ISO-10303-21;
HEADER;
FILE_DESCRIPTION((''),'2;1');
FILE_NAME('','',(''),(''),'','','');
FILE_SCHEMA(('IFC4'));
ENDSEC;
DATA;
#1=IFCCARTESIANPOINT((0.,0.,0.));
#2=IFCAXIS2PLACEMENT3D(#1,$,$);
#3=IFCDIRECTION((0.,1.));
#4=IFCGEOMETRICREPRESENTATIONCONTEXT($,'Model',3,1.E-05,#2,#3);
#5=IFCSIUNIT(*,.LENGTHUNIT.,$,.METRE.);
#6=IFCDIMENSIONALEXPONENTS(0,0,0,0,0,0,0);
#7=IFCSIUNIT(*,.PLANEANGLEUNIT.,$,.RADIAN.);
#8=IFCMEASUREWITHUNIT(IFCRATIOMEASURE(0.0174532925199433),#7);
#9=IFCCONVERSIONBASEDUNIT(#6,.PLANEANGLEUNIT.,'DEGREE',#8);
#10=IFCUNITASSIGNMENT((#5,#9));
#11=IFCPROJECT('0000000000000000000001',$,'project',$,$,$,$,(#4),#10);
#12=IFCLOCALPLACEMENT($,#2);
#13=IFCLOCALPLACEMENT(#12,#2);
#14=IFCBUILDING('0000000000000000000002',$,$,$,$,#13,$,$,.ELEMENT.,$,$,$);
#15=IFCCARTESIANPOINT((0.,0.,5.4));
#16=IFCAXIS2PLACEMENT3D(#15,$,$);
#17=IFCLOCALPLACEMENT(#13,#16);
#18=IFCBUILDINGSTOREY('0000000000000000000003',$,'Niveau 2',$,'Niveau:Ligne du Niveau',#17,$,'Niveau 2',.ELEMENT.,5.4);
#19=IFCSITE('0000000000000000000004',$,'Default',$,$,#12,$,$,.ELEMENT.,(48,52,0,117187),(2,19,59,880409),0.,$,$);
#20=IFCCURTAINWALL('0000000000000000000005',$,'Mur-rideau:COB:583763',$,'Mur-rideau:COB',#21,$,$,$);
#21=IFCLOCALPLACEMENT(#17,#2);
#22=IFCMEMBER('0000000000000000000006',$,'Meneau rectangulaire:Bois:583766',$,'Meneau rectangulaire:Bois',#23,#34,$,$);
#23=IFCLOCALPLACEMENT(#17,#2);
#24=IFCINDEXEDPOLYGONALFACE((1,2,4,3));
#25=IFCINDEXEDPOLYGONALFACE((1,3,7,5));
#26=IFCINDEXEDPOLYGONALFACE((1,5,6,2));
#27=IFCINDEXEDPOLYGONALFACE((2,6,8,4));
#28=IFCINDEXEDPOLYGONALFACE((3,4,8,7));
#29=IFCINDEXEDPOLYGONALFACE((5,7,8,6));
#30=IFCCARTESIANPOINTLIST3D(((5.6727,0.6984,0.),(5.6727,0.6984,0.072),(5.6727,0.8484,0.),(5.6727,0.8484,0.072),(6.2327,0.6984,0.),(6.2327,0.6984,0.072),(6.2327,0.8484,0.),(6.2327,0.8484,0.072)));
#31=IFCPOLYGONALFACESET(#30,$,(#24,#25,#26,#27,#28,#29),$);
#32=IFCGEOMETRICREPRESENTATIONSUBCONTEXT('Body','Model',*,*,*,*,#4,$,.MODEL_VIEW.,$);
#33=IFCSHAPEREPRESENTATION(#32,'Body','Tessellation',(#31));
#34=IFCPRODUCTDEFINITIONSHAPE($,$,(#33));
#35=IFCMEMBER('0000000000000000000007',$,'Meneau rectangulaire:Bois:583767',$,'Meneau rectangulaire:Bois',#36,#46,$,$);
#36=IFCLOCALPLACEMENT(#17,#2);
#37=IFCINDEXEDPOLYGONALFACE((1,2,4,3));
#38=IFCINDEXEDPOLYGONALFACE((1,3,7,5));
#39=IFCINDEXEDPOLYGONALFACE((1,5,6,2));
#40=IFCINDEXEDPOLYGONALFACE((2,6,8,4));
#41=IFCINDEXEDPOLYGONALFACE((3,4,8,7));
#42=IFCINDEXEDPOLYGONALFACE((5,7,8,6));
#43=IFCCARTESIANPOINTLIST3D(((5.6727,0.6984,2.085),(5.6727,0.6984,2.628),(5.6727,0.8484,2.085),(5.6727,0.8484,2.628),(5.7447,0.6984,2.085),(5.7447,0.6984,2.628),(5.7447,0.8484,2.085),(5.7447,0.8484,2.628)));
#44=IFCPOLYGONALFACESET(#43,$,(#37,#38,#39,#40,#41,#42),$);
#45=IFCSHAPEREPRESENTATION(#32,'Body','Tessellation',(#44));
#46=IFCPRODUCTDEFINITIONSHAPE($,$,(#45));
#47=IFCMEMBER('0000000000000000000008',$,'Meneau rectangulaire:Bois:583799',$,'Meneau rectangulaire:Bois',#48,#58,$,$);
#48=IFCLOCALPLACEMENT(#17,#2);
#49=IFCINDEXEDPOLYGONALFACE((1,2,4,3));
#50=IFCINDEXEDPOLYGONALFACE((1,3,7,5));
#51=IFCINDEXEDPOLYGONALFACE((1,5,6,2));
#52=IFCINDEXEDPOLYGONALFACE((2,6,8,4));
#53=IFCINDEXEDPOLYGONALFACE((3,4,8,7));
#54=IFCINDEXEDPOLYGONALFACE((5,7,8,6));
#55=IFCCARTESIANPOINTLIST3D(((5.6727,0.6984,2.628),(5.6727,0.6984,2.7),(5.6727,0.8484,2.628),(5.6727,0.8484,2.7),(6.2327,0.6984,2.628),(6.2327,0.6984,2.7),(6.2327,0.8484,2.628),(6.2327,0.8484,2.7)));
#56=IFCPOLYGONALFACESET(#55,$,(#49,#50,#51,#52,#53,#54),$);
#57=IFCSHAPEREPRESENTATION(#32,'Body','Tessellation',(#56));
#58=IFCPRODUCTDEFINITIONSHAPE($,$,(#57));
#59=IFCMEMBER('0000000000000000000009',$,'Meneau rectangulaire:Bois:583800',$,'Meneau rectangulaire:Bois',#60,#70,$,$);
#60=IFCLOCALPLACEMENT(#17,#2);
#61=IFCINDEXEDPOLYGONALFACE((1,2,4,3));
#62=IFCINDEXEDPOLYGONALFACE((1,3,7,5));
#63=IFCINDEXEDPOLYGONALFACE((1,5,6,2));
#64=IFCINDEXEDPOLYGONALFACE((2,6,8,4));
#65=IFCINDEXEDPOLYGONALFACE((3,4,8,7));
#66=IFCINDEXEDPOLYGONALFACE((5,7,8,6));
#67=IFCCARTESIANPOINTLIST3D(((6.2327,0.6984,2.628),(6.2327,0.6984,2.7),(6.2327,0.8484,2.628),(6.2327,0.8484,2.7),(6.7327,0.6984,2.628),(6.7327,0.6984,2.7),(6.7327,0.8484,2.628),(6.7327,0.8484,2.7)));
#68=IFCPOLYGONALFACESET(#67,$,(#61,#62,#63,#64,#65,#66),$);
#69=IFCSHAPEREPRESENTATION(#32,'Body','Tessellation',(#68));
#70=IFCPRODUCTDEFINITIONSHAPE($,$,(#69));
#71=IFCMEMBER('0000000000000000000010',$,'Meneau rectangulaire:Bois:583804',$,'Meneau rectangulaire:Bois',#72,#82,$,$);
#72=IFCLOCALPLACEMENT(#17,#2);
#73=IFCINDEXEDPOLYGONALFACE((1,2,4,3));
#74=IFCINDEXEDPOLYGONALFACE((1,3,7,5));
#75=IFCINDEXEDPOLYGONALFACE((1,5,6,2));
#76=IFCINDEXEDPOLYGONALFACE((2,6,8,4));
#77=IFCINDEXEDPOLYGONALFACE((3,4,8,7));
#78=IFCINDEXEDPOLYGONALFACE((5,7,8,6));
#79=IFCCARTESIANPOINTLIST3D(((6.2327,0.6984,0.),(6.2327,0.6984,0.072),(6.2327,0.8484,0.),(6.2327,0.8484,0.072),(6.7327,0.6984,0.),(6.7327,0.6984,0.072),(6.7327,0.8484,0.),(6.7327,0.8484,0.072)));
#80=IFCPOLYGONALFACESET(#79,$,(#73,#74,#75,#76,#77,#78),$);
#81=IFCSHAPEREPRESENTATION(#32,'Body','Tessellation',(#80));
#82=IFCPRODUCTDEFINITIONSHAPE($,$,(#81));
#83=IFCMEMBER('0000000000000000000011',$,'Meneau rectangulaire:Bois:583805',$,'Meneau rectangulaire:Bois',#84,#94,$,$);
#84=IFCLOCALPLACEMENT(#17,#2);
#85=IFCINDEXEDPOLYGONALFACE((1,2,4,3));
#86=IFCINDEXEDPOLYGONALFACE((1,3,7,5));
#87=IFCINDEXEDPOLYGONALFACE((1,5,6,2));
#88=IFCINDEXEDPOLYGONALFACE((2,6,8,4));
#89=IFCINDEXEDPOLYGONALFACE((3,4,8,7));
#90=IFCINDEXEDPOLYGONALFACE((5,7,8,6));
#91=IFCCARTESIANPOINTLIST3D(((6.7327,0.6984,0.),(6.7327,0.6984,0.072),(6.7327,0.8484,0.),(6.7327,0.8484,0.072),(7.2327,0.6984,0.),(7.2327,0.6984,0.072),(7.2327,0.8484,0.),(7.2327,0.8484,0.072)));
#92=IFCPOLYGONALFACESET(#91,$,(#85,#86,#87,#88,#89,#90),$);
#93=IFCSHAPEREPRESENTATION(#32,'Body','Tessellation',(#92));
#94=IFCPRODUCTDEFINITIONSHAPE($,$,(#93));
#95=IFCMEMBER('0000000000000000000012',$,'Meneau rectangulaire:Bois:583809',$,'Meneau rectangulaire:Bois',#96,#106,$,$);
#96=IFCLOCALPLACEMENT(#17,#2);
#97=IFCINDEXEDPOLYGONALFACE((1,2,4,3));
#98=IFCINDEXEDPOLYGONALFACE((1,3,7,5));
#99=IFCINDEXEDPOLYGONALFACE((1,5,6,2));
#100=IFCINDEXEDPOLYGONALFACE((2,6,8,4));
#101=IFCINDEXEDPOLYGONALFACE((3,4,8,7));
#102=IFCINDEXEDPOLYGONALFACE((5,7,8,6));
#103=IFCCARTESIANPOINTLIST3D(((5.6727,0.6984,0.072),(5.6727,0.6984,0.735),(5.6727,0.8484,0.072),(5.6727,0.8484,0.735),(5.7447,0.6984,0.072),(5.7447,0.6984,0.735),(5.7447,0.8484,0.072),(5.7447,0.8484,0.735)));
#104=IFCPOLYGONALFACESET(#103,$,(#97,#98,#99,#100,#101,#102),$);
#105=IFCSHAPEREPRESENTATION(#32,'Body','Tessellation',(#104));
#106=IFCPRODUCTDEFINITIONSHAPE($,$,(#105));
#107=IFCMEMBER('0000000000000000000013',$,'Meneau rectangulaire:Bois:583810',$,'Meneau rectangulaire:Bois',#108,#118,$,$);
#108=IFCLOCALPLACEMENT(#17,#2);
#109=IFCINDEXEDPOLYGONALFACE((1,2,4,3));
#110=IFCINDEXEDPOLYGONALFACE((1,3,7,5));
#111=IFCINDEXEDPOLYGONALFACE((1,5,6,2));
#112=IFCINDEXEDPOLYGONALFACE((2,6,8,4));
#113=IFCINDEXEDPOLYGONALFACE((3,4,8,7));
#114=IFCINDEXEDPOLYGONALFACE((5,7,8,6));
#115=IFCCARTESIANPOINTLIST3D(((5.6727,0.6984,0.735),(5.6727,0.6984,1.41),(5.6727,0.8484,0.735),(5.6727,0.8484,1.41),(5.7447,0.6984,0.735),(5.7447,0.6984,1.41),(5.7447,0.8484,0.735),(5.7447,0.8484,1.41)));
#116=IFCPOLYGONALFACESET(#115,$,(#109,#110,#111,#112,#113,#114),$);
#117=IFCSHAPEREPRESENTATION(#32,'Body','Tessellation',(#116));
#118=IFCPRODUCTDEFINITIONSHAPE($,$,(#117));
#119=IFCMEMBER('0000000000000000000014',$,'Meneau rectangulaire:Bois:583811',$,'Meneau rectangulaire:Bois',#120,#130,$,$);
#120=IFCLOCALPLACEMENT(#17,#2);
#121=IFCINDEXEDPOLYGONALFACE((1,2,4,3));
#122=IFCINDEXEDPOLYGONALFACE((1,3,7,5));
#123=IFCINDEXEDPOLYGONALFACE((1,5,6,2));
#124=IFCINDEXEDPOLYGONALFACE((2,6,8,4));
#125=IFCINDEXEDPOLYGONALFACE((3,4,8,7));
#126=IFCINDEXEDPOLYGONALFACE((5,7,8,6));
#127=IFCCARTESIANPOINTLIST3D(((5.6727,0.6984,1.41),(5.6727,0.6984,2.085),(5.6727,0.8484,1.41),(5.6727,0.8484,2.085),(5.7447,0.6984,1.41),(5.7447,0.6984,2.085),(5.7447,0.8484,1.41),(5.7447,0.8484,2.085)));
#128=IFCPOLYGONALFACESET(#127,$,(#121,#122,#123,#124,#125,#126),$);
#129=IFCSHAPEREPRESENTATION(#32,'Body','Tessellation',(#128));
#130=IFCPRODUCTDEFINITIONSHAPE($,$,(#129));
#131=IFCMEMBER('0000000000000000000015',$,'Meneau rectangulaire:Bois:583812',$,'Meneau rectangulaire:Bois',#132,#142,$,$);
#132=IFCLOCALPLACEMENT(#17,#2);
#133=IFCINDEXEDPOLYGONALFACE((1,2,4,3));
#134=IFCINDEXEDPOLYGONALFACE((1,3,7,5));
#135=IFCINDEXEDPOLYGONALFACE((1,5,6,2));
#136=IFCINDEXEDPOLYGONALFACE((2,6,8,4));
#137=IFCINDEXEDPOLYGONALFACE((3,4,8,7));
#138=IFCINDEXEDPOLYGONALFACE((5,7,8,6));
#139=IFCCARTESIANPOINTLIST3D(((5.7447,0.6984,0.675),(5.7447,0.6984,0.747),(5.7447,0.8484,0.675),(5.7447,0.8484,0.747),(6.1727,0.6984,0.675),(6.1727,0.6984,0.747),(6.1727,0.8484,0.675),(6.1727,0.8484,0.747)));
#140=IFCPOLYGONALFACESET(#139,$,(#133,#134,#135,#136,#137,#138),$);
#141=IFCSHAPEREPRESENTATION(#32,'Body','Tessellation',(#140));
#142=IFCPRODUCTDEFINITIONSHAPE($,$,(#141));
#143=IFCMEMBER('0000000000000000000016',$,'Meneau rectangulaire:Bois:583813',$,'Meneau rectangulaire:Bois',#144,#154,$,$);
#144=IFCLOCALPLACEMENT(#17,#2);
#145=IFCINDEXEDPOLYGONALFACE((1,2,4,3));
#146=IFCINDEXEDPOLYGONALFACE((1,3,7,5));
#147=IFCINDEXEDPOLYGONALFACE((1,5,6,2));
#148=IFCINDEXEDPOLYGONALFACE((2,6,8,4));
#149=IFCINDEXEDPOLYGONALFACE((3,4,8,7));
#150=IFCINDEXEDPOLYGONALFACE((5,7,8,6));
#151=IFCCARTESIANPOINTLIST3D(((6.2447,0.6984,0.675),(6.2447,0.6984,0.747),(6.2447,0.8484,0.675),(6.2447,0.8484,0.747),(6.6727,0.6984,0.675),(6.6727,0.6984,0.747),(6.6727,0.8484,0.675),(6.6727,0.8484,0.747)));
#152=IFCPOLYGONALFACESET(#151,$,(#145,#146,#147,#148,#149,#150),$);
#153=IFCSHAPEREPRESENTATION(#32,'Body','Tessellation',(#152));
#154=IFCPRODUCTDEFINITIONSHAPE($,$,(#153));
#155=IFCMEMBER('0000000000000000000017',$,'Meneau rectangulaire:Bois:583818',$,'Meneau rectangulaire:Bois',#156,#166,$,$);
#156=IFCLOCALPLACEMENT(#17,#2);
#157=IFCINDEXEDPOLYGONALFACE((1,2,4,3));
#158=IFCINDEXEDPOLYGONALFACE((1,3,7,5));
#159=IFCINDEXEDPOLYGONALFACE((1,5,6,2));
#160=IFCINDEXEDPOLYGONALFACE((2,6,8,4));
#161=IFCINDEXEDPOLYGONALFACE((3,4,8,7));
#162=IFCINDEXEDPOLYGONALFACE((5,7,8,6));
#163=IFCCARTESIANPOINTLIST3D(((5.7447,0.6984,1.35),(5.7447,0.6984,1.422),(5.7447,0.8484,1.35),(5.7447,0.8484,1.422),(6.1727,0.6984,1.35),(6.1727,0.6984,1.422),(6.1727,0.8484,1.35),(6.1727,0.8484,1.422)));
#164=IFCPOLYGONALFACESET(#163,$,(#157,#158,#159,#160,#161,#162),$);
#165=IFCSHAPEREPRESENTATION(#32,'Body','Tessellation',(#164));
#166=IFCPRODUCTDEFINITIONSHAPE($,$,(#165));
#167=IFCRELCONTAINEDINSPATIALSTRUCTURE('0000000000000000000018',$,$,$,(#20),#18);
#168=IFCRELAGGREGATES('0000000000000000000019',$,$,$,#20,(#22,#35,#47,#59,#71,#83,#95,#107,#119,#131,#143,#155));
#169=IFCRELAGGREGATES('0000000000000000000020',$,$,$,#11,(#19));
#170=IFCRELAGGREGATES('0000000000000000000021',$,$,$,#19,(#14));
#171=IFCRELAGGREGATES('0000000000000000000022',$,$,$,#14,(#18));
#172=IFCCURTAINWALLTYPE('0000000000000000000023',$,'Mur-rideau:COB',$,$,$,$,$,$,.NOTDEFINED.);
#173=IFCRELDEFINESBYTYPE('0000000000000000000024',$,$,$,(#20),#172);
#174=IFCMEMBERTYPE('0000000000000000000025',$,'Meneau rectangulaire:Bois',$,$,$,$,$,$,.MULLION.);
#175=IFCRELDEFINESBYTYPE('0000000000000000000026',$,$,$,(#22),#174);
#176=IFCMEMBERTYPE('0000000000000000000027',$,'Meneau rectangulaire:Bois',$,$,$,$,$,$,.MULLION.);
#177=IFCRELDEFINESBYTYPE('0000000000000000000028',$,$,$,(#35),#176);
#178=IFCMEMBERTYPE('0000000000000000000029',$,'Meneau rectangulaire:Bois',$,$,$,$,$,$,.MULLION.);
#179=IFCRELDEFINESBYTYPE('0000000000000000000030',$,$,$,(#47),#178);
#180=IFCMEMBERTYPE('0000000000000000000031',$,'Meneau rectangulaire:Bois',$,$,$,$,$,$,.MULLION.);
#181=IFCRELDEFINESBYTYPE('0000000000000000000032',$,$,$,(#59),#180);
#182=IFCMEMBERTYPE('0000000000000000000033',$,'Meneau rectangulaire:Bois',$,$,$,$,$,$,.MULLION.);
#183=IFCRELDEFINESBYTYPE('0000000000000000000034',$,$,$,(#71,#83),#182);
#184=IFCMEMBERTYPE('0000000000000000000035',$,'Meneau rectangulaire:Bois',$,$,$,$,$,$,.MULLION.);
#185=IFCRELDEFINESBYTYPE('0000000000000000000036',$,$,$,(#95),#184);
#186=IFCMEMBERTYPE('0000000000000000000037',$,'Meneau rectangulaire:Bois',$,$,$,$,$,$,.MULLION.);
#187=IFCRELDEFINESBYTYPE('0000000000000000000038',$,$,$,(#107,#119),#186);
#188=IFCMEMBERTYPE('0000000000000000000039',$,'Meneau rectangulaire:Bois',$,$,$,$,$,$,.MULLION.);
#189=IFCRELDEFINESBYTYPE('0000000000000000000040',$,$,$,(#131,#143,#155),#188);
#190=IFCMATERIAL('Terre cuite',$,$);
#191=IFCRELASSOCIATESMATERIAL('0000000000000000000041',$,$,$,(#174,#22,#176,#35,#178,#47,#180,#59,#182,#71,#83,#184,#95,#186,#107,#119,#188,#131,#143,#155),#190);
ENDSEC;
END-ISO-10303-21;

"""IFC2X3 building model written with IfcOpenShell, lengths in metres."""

from ifc_helpers import new_model, entity, si_unit, converted_unit, direction, frame, origin, origin_2d_with_axis, place, context, subcontext, project, spatial, rectangle, extrude, source, transform, mapped, material, type_object, type_shapes, element, aggregate, save


model = new_model("IFC2X3")

# Units and contexts
model_context = context("Model", 3, precision=1e-05, world=origin(), true_north=direction((0.0, 1.0)))
body_context = subcontext(model_context, "Body", "Model", "MODEL_VIEW")
ifc_project = project(units=[si_unit("LENGTHUNIT", "METRE"), converted_unit("PLANEANGLEUNIT", "DEGREE", entity("IfcRatioMeasure", 0.0174532925199433), si_unit("PLANEANGLEUNIT", "RADIAN"), dimensions=[0, 0, 0, 0, 0, 0, 0])], contexts=[model_context])

# Site, building, storey
site_placement = place(None, origin())
site = spatial("IfcSite", under=ifc_project, at=site_placement, Name="Default", CompositionType="ELEMENT", RefLatitude=(48, 52, 0, 117187), RefLongitude=(2, 19, 59, 880409), RefElevation=0.0)
building_placement = place(site_placement, origin())
building = spatial("IfcBuilding", under=site, at=building_placement, CompositionType="ELEMENT")
storey_placement = place(building_placement, frame((0.0, 0.0, 5.4)))
storey = spatial("IfcBuildingStorey", under=building, at=storey_placement, Name="Niveau 2", ObjectType="Niveau:Ligne du Niveau", LongName="Niveau 2", CompositionType="ELEMENT", Elevation=5.4)

# Curtain wall, members
curtain_wall_type_1 = type_object("IfcCurtainWallType", Name="Mur-rideau:COB", PredefinedType="NOTDEFINED")
curtain_wall_1_placement = place(storey_placement, frame((0.0, 0.0, -5.4)))
curtain_wall_1 = element("IfcCurtainWall", 1, at=curtain_wall_1_placement, inside=storey, type_object=curtain_wall_type_1, Name="Mur-rideau:COB:583763", ObjectType="Mur-rideau:COB")
ifc_material_1 = material(Name="Terre cuite")
member_type_1 = type_object("IfcMemberType", Name="Meneau rectangulaire:Bois", PredefinedType="MULLION", material=ifc_material_1)
shared_shape_1 = source(origin(), body_context, "Body", "SweptSolid", [
    extrude(rectangle(XDim=0.15, YDim=0.072, at=origin_2d_with_axis()), frame((-0.036, 0.0, -0.56), z_axis=(0.0, 0.0, 1.0), x_axis=(0.0, -1.0, 0.0)), (0.0, 0.0, 1.0), 0.56),
])
type_shapes(member_type_1, [shared_shape_1])
member_1_placement = place(storey_placement, frame((5.6727, 0.7734, 0.0), z_axis=(-1.0, 0.0, 0.0), x_axis=(0.0, 0.0, -1.0)))
member_1 = element("IfcMember", 2, at=member_1_placement, type_object=member_type_1, material=ifc_material_1, Name="Meneau rectangulaire:Bois:583766", ObjectType="Meneau rectangulaire:Bois", context=body_context, shape_type="MappedRepresentation", body=[
    mapped(shared_shape_1, transform((0.0, 0.0, 0.0), scale=1.0)),
])
member_type_2 = type_object("IfcMemberType", Name="Meneau rectangulaire:Bois", PredefinedType="MULLION", material=ifc_material_1)
shared_shape_2 = source(origin(), body_context, "Body", "SweptSolid", [
    extrude(rectangle(XDim=0.15, YDim=0.072, at=origin_2d_with_axis()), frame((-0.036, 0.0, -0.543), z_axis=(0.0, 0.0, 1.0), x_axis=(0.0, -1.0, 0.0)), (0.0, 0.0, 1.0), 0.543),
])
type_shapes(member_type_2, [shared_shape_2])
member_2_placement = place(storey_placement, frame((5.6727, 0.7734, 2.628), z_axis=(0.0, 0.0, 1.0), x_axis=(-1.0, 0.0, 0.0)))
member_2 = element("IfcMember", 3, at=member_2_placement, type_object=member_type_2, material=ifc_material_1, Name="Meneau rectangulaire:Bois:583767", ObjectType="Meneau rectangulaire:Bois", context=body_context, shape_type="MappedRepresentation", body=[
    mapped(shared_shape_2, transform((0.0, 0.0, 0.0), scale=1.0)),
])
member_type_3 = type_object("IfcMemberType", Name="Meneau rectangulaire:Bois", PredefinedType="MULLION", material=ifc_material_1)
shared_shape_3 = source(origin(), body_context, "Body", "SweptSolid", [
    extrude(rectangle(XDim=0.15, YDim=0.072, at=origin_2d_with_axis()), frame((-0.036, 0.0, -0.56), z_axis=(0.0, 0.0, 1.0), x_axis=(0.0, -1.0, 0.0)), (0.0, 0.0, 1.0), 0.56),
])
type_shapes(member_type_3, [shared_shape_3])
member_3_placement = place(storey_placement, frame((6.2327, 0.7734, 2.7), z_axis=(1.0, 0.0, 0.0), x_axis=(0.0, 0.0, 1.0)))
member_3 = element("IfcMember", 4, at=member_3_placement, type_object=member_type_3, material=ifc_material_1, Name="Meneau rectangulaire:Bois:583799", ObjectType="Meneau rectangulaire:Bois", context=body_context, shape_type="MappedRepresentation", body=[
    mapped(shared_shape_3, transform((0.0, 0.0, 0.0), scale=1.0)),
])
member_type_4 = type_object("IfcMemberType", Name="Meneau rectangulaire:Bois", PredefinedType="MULLION", material=ifc_material_1)
shared_shape_4 = source(origin(), body_context, "Body", "SweptSolid", [
    extrude(rectangle(XDim=0.15, YDim=0.072, at=origin_2d_with_axis()), frame((-0.036, 0.0, -0.5), z_axis=(0.0, 0.0, 1.0), x_axis=(0.0, -1.0, 0.0)), (0.0, 0.0, 1.0), 0.5),
])
type_shapes(member_type_4, [shared_shape_4])
member_4_placement = place(storey_placement, frame((6.7327, 0.7734, 2.7), z_axis=(1.0, 0.0, 0.0), x_axis=(0.0, 0.0, 1.0)))
member_4 = element("IfcMember", 5, at=member_4_placement, type_object=member_type_4, material=ifc_material_1, Name="Meneau rectangulaire:Bois:583800", ObjectType="Meneau rectangulaire:Bois", context=body_context, shape_type="MappedRepresentation", body=[
    mapped(shared_shape_4, transform((0.0, 0.0, 0.0), scale=1.0)),
])
member_type_5 = type_object("IfcMemberType", Name="Meneau rectangulaire:Bois", PredefinedType="MULLION", material=ifc_material_1)
shared_shape_5 = source(origin(), body_context, "Body", "SweptSolid", [
    extrude(rectangle(XDim=0.15, YDim=0.072, at=origin_2d_with_axis()), frame((-0.036, 0.0, -0.5), z_axis=(0.0, 0.0, 1.0), x_axis=(0.0, -1.0, 0.0)), (0.0, 0.0, 1.0), 0.5),
])
type_shapes(member_type_5, [shared_shape_5])
member_5_placement = place(storey_placement, frame((6.2327, 0.7734, 0.0), z_axis=(-1.0, 0.0, 0.0), x_axis=(0.0, 0.0, -1.0)))
member_5 = element("IfcMember", 6, at=member_5_placement, type_object=member_type_5, material=ifc_material_1, Name="Meneau rectangulaire:Bois:583804", ObjectType="Meneau rectangulaire:Bois", context=body_context, shape_type="MappedRepresentation", body=[
    mapped(shared_shape_5, transform((0.0, 0.0, 0.0), scale=1.0)),
])
member_6_placement = place(storey_placement, frame((6.7327, 0.7734, 0.0), z_axis=(-1.0, 0.0, 0.0), x_axis=(0.0, 0.0, -1.0)))
member_6 = element("IfcMember", 7, at=member_6_placement, type_object=member_type_5, material=ifc_material_1, Name="Meneau rectangulaire:Bois:583805", ObjectType="Meneau rectangulaire:Bois", context=body_context, shape_type="MappedRepresentation", body=[
    mapped(shared_shape_5, transform((0.0, 0.0, 0.0), scale=1.0)),
])
member_type_6 = type_object("IfcMemberType", Name="Meneau rectangulaire:Bois", PredefinedType="MULLION", material=ifc_material_1)
shared_shape_6 = source(origin(), body_context, "Body", "SweptSolid", [
    extrude(rectangle(XDim=0.15, YDim=0.072, at=origin_2d_with_axis()), frame((-0.036, 0.0, -0.663), z_axis=(0.0, 0.0, 1.0), x_axis=(0.0, -1.0, 0.0)), (0.0, 0.0, 1.0), 0.663),
])
type_shapes(member_type_6, [shared_shape_6])
member_7_placement = place(storey_placement, frame((5.6727, 0.7734, 0.735), z_axis=(0.0, 0.0, 1.0), x_axis=(-1.0, 0.0, 0.0)))
member_7 = element("IfcMember", 8, at=member_7_placement, type_object=member_type_6, material=ifc_material_1, Name="Meneau rectangulaire:Bois:583809", ObjectType="Meneau rectangulaire:Bois", context=body_context, shape_type="MappedRepresentation", body=[
    mapped(shared_shape_6, transform((0.0, 0.0, 0.0), scale=1.0)),
])
member_type_7 = type_object("IfcMemberType", Name="Meneau rectangulaire:Bois", PredefinedType="MULLION", material=ifc_material_1)
shared_shape_7 = source(origin(), body_context, "Body", "SweptSolid", [
    extrude(rectangle(XDim=0.15, YDim=0.072, at=origin_2d_with_axis()), frame((-0.036, 0.0, -0.675), z_axis=(0.0, 0.0, 1.0), x_axis=(0.0, -1.0, 0.0)), (0.0, 0.0, 1.0), 0.675),
])
type_shapes(member_type_7, [shared_shape_7])
member_8_placement = place(storey_placement, frame((5.6727, 0.7734, 1.41), z_axis=(0.0, 0.0, 1.0), x_axis=(-1.0, 0.0, 0.0)))
member_8 = element("IfcMember", 9, at=member_8_placement, type_object=member_type_7, material=ifc_material_1, Name="Meneau rectangulaire:Bois:583810", ObjectType="Meneau rectangulaire:Bois", context=body_context, shape_type="MappedRepresentation", body=[
    mapped(shared_shape_7, transform((0.0, 0.0, 0.0), scale=1.0)),
])
member_9_placement = place(storey_placement, frame((5.6727, 0.7734, 2.085), z_axis=(0.0, 0.0, 1.0), x_axis=(-1.0, 0.0, 0.0)))
member_9 = element("IfcMember", 10, at=member_9_placement, type_object=member_type_7, material=ifc_material_1, Name="Meneau rectangulaire:Bois:583811", ObjectType="Meneau rectangulaire:Bois", context=body_context, shape_type="MappedRepresentation", body=[
    mapped(shared_shape_7, transform((0.0, 0.0, 0.0), scale=1.0)),
])
member_type_8 = type_object("IfcMemberType", Name="Meneau rectangulaire:Bois", PredefinedType="MULLION", material=ifc_material_1)
shared_shape_8 = source(origin(), body_context, "Body", "SweptSolid", [
    extrude(rectangle(XDim=0.15, YDim=0.072, at=origin_2d_with_axis()), frame((-0.024, 0.0, -0.428), z_axis=(0.0, 0.0, 1.0), x_axis=(0.0, -1.0, 0.0)), (0.0, 0.0, 1.0), 0.428),
])
type_shapes(member_type_8, [shared_shape_8])
member_10_placement = place(storey_placement, frame((6.1727, 0.7734, 0.735), z_axis=(1.0, 0.0, 0.0), x_axis=(0.0, 0.0, 1.0)))
member_10 = element("IfcMember", 11, at=member_10_placement, type_object=member_type_8, material=ifc_material_1, Name="Meneau rectangulaire:Bois:583812", ObjectType="Meneau rectangulaire:Bois", context=body_context, shape_type="MappedRepresentation", body=[
    mapped(shared_shape_8, transform((0.0, 0.0, 0.0), scale=1.0)),
])
member_11_placement = place(storey_placement, frame((6.6727, 0.7734, 0.735), z_axis=(1.0, 0.0, 0.0), x_axis=(0.0, 0.0, 1.0)))
member_11 = element("IfcMember", 12, at=member_11_placement, type_object=member_type_8, material=ifc_material_1, Name="Meneau rectangulaire:Bois:583813", ObjectType="Meneau rectangulaire:Bois", context=body_context, shape_type="MappedRepresentation", body=[
    mapped(shared_shape_8, transform((0.0, 0.0, 0.0), scale=1.0)),
])
member_12_placement = place(storey_placement, frame((6.1727, 0.7734, 1.41), z_axis=(1.0, 0.0, 0.0), x_axis=(0.0, 0.0, 1.0)))
member_12 = element("IfcMember", 13, at=member_12_placement, type_object=member_type_8, material=ifc_material_1, Name="Meneau rectangulaire:Bois:583818", ObjectType="Meneau rectangulaire:Bois", context=body_context, shape_type="MappedRepresentation", body=[
    mapped(shared_shape_8, transform((0.0, 0.0, 0.0), scale=1.0)),
])
aggregate(curtain_wall_1, [member_1, member_2, member_3, member_4, member_5, member_6, member_7, member_8, member_9, member_10, member_11, member_12])

save(model, "model.ifc")
